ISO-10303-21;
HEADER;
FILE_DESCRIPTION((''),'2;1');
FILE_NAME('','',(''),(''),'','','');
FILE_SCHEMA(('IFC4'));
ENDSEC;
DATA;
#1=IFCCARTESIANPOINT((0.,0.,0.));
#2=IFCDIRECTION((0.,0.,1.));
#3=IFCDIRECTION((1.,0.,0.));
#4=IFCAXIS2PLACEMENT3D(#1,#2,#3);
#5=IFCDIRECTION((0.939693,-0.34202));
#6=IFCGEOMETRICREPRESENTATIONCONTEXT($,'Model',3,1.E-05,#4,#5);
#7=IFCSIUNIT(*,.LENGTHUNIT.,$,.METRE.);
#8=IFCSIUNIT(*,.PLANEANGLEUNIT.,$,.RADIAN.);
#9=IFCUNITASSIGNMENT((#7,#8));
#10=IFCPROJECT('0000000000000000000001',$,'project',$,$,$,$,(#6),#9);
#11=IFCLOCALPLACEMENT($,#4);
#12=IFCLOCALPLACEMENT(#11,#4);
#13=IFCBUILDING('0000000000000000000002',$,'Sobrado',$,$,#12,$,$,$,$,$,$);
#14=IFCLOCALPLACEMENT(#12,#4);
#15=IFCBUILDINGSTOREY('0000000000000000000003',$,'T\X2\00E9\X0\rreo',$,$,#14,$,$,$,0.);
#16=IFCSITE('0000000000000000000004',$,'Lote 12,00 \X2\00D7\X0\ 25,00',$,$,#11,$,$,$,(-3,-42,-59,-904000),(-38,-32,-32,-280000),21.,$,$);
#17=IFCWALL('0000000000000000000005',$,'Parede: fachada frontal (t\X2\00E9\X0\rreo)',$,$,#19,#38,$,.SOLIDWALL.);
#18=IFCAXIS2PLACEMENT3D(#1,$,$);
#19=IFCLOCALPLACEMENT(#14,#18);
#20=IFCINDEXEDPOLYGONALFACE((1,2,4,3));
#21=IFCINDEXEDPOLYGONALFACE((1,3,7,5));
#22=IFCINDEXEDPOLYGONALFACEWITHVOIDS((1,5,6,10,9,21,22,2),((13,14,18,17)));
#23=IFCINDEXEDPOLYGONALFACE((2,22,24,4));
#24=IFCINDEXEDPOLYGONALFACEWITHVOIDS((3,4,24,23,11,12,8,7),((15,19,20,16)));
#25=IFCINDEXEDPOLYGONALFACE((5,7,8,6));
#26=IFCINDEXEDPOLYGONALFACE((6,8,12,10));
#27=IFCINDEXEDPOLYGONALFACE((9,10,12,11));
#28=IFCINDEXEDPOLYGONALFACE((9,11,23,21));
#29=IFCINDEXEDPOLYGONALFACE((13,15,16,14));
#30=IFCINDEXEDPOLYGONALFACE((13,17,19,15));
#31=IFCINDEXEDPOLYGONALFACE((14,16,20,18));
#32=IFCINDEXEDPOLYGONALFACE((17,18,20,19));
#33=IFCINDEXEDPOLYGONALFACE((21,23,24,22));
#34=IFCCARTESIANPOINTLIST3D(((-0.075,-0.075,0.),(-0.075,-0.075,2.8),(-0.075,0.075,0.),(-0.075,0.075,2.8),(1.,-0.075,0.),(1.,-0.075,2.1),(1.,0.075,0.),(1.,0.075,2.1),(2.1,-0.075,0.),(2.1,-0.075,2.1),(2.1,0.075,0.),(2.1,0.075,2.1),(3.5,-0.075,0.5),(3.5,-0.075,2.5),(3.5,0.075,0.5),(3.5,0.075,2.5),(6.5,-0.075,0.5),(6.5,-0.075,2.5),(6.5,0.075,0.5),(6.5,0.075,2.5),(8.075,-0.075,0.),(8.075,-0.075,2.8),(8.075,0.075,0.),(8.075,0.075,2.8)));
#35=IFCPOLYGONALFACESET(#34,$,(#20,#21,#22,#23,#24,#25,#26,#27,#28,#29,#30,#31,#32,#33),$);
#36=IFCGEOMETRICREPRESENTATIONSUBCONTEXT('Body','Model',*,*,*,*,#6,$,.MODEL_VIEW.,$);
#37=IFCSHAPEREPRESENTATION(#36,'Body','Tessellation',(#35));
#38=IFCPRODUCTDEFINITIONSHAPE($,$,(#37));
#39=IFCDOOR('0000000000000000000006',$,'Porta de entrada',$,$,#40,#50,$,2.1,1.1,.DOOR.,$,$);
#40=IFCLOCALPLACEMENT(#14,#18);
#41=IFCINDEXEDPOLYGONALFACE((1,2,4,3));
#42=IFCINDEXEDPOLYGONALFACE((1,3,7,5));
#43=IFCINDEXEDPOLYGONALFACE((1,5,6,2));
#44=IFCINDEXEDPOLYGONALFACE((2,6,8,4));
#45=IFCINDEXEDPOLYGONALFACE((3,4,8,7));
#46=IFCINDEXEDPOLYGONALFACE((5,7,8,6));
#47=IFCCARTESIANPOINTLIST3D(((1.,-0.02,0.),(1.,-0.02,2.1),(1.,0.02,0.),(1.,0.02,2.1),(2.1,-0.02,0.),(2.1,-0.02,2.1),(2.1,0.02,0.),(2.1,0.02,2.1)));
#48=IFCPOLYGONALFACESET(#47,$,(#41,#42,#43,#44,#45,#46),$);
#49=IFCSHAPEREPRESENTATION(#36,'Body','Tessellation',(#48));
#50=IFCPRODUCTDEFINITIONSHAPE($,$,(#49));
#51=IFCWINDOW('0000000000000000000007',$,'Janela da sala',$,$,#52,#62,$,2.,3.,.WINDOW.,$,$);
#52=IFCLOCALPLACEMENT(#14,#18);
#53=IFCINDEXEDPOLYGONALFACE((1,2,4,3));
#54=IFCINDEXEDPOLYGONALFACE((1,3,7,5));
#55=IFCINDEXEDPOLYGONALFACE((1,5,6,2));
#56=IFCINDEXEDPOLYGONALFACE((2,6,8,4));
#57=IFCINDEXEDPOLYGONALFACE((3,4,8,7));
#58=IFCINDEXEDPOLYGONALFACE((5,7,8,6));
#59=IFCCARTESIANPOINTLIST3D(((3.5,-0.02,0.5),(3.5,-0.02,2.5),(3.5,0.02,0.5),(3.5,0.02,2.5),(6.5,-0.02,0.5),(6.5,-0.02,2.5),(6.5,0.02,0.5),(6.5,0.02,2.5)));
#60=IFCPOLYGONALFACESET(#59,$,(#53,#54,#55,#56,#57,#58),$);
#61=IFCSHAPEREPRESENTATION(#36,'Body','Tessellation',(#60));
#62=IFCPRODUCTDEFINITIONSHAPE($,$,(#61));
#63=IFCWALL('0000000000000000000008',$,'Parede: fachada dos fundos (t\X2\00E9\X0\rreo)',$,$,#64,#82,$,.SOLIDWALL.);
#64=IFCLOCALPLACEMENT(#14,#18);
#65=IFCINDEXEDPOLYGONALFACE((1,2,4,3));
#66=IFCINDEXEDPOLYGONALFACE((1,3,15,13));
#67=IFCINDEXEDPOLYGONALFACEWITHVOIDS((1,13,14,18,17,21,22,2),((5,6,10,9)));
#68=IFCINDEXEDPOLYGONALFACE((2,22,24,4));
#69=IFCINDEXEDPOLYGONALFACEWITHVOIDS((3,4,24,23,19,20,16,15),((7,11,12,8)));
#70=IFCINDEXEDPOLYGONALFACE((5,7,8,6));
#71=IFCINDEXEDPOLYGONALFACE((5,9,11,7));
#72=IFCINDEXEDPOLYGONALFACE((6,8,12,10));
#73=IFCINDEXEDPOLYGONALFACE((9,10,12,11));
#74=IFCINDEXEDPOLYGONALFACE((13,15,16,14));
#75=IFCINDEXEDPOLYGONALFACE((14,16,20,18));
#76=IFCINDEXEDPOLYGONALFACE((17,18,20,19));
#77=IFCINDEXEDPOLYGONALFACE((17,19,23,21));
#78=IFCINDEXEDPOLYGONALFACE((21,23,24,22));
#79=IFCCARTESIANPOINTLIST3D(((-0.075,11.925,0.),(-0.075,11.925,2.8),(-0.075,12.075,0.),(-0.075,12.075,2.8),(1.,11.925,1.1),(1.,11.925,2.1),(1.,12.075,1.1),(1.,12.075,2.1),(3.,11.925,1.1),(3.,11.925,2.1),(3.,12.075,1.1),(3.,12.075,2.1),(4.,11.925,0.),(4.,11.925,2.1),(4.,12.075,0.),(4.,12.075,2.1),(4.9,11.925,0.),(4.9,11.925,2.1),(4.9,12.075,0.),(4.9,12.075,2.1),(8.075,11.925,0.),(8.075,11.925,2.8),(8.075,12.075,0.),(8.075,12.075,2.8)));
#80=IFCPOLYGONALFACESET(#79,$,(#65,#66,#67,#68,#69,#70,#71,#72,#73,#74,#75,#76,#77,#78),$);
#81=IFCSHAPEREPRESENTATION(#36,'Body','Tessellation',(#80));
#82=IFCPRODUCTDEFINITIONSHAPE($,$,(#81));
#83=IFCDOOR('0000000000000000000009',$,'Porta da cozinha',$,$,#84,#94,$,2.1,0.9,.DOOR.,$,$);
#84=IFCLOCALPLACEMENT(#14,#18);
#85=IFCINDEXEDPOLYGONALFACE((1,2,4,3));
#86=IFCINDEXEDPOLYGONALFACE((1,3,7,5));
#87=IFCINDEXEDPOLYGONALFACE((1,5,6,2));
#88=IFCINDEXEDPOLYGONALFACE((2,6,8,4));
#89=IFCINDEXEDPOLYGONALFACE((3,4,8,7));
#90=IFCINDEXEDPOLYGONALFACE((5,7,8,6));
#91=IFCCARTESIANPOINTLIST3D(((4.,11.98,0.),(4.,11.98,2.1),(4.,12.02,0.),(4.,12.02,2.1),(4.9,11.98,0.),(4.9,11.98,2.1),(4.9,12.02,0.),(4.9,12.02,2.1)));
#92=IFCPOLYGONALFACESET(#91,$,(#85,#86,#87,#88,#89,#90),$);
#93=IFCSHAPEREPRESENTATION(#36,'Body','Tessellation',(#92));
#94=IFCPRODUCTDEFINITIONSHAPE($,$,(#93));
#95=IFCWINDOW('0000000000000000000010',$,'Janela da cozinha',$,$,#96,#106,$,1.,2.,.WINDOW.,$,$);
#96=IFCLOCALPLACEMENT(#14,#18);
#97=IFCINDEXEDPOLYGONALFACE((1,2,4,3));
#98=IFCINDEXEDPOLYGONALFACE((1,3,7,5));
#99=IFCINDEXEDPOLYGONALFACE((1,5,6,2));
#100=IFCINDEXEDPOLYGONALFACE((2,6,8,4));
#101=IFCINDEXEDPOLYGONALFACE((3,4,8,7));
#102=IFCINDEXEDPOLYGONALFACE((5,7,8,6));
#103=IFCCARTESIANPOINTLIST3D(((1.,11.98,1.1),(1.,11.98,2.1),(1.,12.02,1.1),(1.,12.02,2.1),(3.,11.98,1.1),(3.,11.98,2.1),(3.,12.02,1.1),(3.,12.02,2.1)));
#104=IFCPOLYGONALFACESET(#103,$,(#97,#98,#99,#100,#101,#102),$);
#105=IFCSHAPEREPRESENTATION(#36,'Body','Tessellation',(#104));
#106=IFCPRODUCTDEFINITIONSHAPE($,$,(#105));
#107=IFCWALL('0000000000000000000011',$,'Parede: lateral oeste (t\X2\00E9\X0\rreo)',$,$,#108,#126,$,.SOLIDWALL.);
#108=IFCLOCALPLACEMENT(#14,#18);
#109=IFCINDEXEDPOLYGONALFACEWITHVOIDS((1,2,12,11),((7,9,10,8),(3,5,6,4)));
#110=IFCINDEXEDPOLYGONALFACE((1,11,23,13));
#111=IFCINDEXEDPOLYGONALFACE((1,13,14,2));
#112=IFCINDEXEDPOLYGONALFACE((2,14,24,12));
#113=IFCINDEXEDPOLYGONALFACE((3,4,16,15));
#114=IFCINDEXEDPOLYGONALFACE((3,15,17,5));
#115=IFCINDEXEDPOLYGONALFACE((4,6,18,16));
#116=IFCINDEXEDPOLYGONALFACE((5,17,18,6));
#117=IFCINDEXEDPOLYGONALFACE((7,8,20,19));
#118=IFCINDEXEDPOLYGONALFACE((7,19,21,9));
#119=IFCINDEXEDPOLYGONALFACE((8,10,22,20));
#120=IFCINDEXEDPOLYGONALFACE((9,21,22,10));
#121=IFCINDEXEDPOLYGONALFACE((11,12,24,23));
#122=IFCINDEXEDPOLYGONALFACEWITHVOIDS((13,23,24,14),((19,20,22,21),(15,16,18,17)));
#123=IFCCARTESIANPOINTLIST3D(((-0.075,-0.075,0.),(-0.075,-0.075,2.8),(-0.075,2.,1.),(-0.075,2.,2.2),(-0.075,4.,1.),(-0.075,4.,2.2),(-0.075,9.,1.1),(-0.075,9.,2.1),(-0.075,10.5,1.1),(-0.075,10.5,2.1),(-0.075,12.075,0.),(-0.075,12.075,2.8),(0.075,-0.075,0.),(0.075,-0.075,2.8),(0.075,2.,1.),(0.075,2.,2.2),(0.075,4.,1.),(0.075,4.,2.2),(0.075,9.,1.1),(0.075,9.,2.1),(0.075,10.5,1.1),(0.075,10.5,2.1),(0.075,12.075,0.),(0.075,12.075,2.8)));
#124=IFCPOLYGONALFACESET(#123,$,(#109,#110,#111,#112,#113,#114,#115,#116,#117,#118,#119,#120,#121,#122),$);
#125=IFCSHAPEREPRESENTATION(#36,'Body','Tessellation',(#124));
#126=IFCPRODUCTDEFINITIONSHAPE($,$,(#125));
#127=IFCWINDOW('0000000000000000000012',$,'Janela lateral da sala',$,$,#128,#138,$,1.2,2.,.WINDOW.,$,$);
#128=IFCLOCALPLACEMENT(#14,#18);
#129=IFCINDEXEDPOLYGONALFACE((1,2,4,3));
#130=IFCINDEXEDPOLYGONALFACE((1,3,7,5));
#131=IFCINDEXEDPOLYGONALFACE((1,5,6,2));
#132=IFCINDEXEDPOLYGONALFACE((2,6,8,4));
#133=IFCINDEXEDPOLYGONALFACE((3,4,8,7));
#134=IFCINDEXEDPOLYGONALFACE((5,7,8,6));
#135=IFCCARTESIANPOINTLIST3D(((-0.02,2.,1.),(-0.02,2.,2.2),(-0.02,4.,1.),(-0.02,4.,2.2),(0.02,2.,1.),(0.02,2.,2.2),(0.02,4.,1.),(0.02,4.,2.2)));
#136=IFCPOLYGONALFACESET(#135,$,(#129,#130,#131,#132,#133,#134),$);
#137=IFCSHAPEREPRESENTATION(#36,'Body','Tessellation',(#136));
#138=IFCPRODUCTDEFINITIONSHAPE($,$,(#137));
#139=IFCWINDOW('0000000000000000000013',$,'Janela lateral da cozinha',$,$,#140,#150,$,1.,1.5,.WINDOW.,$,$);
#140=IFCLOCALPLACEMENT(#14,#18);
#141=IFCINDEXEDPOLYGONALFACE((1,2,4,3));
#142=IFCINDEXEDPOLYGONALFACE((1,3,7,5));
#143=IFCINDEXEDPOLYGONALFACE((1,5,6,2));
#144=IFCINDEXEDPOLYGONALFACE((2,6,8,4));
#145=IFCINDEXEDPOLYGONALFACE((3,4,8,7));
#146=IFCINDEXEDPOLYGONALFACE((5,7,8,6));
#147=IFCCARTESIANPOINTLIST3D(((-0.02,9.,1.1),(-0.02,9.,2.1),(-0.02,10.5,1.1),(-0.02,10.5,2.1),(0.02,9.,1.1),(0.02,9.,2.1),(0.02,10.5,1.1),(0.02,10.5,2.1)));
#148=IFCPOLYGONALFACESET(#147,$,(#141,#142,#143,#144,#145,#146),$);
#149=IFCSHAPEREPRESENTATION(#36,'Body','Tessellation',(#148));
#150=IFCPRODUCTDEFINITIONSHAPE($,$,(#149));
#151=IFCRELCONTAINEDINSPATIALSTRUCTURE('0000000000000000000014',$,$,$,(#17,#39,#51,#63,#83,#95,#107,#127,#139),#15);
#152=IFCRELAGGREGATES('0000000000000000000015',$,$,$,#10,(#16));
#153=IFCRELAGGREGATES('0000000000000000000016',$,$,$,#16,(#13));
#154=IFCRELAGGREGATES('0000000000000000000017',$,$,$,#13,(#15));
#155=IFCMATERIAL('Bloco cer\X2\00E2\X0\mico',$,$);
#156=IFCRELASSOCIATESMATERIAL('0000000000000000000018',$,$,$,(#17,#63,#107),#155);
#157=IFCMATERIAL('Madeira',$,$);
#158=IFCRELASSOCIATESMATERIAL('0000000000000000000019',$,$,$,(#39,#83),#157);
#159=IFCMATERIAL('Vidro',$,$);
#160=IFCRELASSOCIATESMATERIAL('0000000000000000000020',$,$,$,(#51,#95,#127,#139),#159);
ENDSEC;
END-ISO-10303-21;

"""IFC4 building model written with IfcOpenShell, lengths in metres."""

from ifc_helpers import new_model, si_unit, direction, frame, origin_with_axes, place, context, subcontext, project, spatial, line, indexed_curve, outline, extrude, material, element, fill, save


model = new_model("IFC4")

# Units and contexts
model_context = context("Model", 3, precision=1e-05, world=origin_with_axes(), true_north=direction((0.939693, -0.34202)))
body_context = subcontext(model_context, "Body", "Model", "MODEL_VIEW")
ifc_project = project(units=[si_unit("LENGTHUNIT", "METRE"), si_unit("PLANEANGLEUNIT", "RADIAN")], contexts=[model_context])

# Site, building, storey
site_placement = place(None, origin_with_axes())
site = spatial("IfcSite", under=ifc_project, at=site_placement, Name="Lote 12,00 × 25,00", RefLatitude=(-3, -42, -59, -904000), RefLongitude=(-38, -32, -32, -280000), RefElevation=21.0)
building_placement = place(site_placement, origin_with_axes())
building = spatial("IfcBuilding", under=site, at=building_placement, Name="Sobrado")
storey_placement = place(building_placement, origin_with_axes())
storey = spatial("IfcBuildingStorey", under=building, at=storey_placement, Name="Térreo", Elevation=0.0)

# Shared definitions
ifc_material_1 = material(Name="Concreto armado")

# Walls, openings, doors, windows
ifc_material_2 = material(Name="Bloco cerâmico")
wall_1_placement = place(storey_placement, origin_with_axes())
wall_1 = element("IfcWall", 1, at=wall_1_placement, inside=storey, material=ifc_material_2, Name="Parede: fachada frontal (térreo)", PredefinedType="SOLIDWALL", context=body_context, shape_type="SweptSolid", body=[
    extrude(outline(indexed_curve([(-0.075, -0.075), (8.075, -0.075), (8.075, 0.075), (-0.075, 0.075)], segments=[line(1, 2, 3, 4, 1)])), origin_with_axes(), (0.0, 0.0, 1.0), 2.8),
])
opening_1_placement = place(wall_1_placement, origin_with_axes())
opening_1 = element("IfcOpeningElement", 2, at=opening_1_placement, cuts=wall_1, material=ifc_material_1, PredefinedType="OPENING", context=body_context, shape_type="SweptSolid", body=[
    extrude(outline(indexed_curve([(1.0, -0.125), (2.1, -0.125), (2.1, 0.125), (1.0, 0.125)], segments=[line(1, 2, 3, 4, 1)])), origin_with_axes(), (0.0, 0.0, 1.0), 2.1),
])
opening_2_placement = place(wall_1_placement, origin_with_axes())
opening_2 = element("IfcOpeningElement", 3, at=opening_2_placement, cuts=wall_1, material=ifc_material_1, PredefinedType="OPENING", context=body_context, shape_type="SweptSolid", body=[
    extrude(outline(indexed_curve([(3.5, -0.125), (6.5, -0.125), (6.5, 0.125), (3.5, 0.125)], segments=[line(1, 2, 3, 4, 1)])), frame((0.0, 0.0, 0.5), z_axis=(0.0, 0.0, 1.0), x_axis=(1.0, 0.0, 0.0)), (0.0, 0.0, 1.0), 2.0),
])
ifc_material_3 = material(Name="Madeira")
door_1_placement = place(storey_placement, origin_with_axes())
door_1 = element("IfcDoor", 4, at=door_1_placement, inside=storey, material=ifc_material_3, Name="Porta de entrada", OverallHeight=2.1, OverallWidth=1.1, PredefinedType="DOOR", context=body_context, shape_type="SweptSolid", body=[
    extrude(outline(indexed_curve([(1.0, -0.02), (2.1, -0.02), (2.1, 0.02), (1.0, 0.02)], segments=[line(1, 2, 3, 4, 1)])), origin_with_axes(), (0.0, 0.0, 1.0), 2.1),
])
fill(opening_1, door_1)
ifc_material_4 = material(Name="Vidro")
window_1_placement = place(storey_placement, origin_with_axes())
window_1 = element("IfcWindow", 5, at=window_1_placement, inside=storey, material=ifc_material_4, Name="Janela da sala", OverallHeight=2.0, OverallWidth=3.0, PredefinedType="WINDOW", context=body_context, shape_type="SweptSolid", body=[
    extrude(outline(indexed_curve([(3.5, -0.02), (6.5, -0.02), (6.5, 0.02), (3.5, 0.02)], segments=[line(1, 2, 3, 4, 1)])), frame((0.0, 0.0, 0.5), z_axis=(0.0, 0.0, 1.0), x_axis=(1.0, 0.0, 0.0)), (0.0, 0.0, 1.0), 2.0),
])
fill(opening_2, window_1)
wall_2_placement = place(storey_placement, origin_with_axes())
wall_2 = element("IfcWall", 6, at=wall_2_placement, inside=storey, material=ifc_material_2, Name="Parede: fachada dos fundos (térreo)", PredefinedType="SOLIDWALL", context=body_context, shape_type="SweptSolid", body=[
    extrude(outline(indexed_curve([(-0.075, 11.925), (8.075, 11.925), (8.075, 12.075), (-0.075, 12.075)], segments=[line(1, 2, 3, 4, 1)])), origin_with_axes(), (0.0, 0.0, 1.0), 2.8),
])
opening_3_placement = place(wall_2_placement, origin_with_axes())
opening_3 = element("IfcOpeningElement", 7, at=opening_3_placement, cuts=wall_2, material=ifc_material_1, PredefinedType="OPENING", context=body_context, shape_type="SweptSolid", body=[
    extrude(outline(indexed_curve([(4.0, 11.875), (4.9, 11.875), (4.9, 12.125), (4.0, 12.125)], segments=[line(1, 2, 3, 4, 1)])), origin_with_axes(), (0.0, 0.0, 1.0), 2.1),
])
opening_4_placement = place(wall_2_placement, origin_with_axes())
opening_4 = element("IfcOpeningElement", 8, at=opening_4_placement, cuts=wall_2, material=ifc_material_1, PredefinedType="OPENING", context=body_context, shape_type="SweptSolid", body=[
    extrude(outline(indexed_curve([(1.0, 11.875), (3.0, 11.875), (3.0, 12.125), (1.0, 12.125)], segments=[line(1, 2, 3, 4, 1)])), frame((0.0, 0.0, 1.1), z_axis=(0.0, 0.0, 1.0), x_axis=(1.0, 0.0, 0.0)), (0.0, 0.0, 1.0), 1.0),
])
door_2_placement = place(storey_placement, origin_with_axes())
door_2 = element("IfcDoor", 9, at=door_2_placement, inside=storey, material=ifc_material_3, Name="Porta da cozinha", OverallHeight=2.1, OverallWidth=0.9, PredefinedType="DOOR", context=body_context, shape_type="SweptSolid", body=[
    extrude(outline(indexed_curve([(4.0, 11.98), (4.9, 11.98), (4.9, 12.02), (4.0, 12.02)], segments=[line(1, 2, 3, 4, 1)])), origin_with_axes(), (0.0, 0.0, 1.0), 2.1),
])
fill(opening_3, door_2)
window_2_placement = place(storey_placement, origin_with_axes())
window_2 = element("IfcWindow", 10, at=window_2_placement, inside=storey, material=ifc_material_4, Name="Janela da cozinha", OverallHeight=1.0, OverallWidth=2.0, PredefinedType="WINDOW", context=body_context, shape_type="SweptSolid", body=[
    extrude(outline(indexed_curve([(1.0, 11.98), (3.0, 11.98), (3.0, 12.02), (1.0, 12.02)], segments=[line(1, 2, 3, 4, 1)])), frame((0.0, 0.0, 1.1), z_axis=(0.0, 0.0, 1.0), x_axis=(1.0, 0.0, 0.0)), (0.0, 0.0, 1.0), 1.0),
])
fill(opening_4, window_2)

# Wall, openings, windows
wall_3_placement = place(storey_placement, origin_with_axes())
wall_3 = element("IfcWall", 11, at=wall_3_placement, inside=storey, material=ifc_material_2, Name="Parede: lateral oeste (térreo)", PredefinedType="SOLIDWALL", context=body_context, shape_type="SweptSolid", body=[
    extrude(outline(indexed_curve([(-0.075, -0.075), (0.075, -0.075), (0.075, 12.075), (-0.075, 12.075)], segments=[line(1, 2, 3, 4, 1)])), origin_with_axes(), (0.0, 0.0, 1.0), 2.8),
])
opening_5_placement = place(wall_3_placement, origin_with_axes())
opening_5 = element("IfcOpeningElement", 12, at=opening_5_placement, cuts=wall_3, material=ifc_material_1, PredefinedType="OPENING", context=body_context, shape_type="SweptSolid", body=[
    extrude(outline(indexed_curve([(-0.125, 2.0), (0.125, 2.0), (0.125, 4.0), (-0.125, 4.0)], segments=[line(1, 2, 3, 4, 1)])), frame((0.0, 0.0, 1.0), z_axis=(0.0, 0.0, 1.0), x_axis=(1.0, 0.0, 0.0)), (0.0, 0.0, 1.0), 1.2),
])
opening_6_placement = place(wall_3_placement, origin_with_axes())
opening_6 = element("IfcOpeningElement", 13, at=opening_6_placement, cuts=wall_3, material=ifc_material_1, PredefinedType="OPENING", context=body_context, shape_type="SweptSolid", body=[
    extrude(outline(indexed_curve([(-0.125, 9.0), (0.125, 9.0), (0.125, 10.5), (-0.125, 10.5)], segments=[line(1, 2, 3, 4, 1)])), frame((0.0, 0.0, 1.1), z_axis=(0.0, 0.0, 1.0), x_axis=(1.0, 0.0, 0.0)), (0.0, 0.0, 1.0), 1.0),
])
window_3_placement = place(storey_placement, origin_with_axes())
window_3 = element("IfcWindow", 14, at=window_3_placement, inside=storey, material=ifc_material_4, Name="Janela lateral da sala", OverallHeight=1.2, OverallWidth=2.0, PredefinedType="WINDOW", context=body_context, shape_type="SweptSolid", body=[
    extrude(outline(indexed_curve([(-0.02, 2.0), (0.02, 2.0), (0.02, 4.0), (-0.02, 4.0)], segments=[line(1, 2, 3, 4, 1)])), frame((0.0, 0.0, 1.0), z_axis=(0.0, 0.0, 1.0), x_axis=(1.0, 0.0, 0.0)), (0.0, 0.0, 1.0), 1.2),
])
fill(opening_5, window_3)
window_4_placement = place(storey_placement, origin_with_axes())
window_4 = element("IfcWindow", 15, at=window_4_placement, inside=storey, material=ifc_material_4, Name="Janela lateral da cozinha", OverallHeight=1.0, OverallWidth=1.5, PredefinedType="WINDOW", context=body_context, shape_type="SweptSolid", body=[
    extrude(outline(indexed_curve([(-0.02, 9.0), (0.02, 9.0), (0.02, 10.5), (-0.02, 10.5)], segments=[line(1, 2, 3, 4, 1)])), frame((0.0, 0.0, 1.1), z_axis=(0.0, 0.0, 1.0), x_axis=(1.0, 0.0, 0.0)), (0.0, 0.0, 1.0), 1.0),
])
fill(opening_6, window_4)

save(model, "model.ifc")
